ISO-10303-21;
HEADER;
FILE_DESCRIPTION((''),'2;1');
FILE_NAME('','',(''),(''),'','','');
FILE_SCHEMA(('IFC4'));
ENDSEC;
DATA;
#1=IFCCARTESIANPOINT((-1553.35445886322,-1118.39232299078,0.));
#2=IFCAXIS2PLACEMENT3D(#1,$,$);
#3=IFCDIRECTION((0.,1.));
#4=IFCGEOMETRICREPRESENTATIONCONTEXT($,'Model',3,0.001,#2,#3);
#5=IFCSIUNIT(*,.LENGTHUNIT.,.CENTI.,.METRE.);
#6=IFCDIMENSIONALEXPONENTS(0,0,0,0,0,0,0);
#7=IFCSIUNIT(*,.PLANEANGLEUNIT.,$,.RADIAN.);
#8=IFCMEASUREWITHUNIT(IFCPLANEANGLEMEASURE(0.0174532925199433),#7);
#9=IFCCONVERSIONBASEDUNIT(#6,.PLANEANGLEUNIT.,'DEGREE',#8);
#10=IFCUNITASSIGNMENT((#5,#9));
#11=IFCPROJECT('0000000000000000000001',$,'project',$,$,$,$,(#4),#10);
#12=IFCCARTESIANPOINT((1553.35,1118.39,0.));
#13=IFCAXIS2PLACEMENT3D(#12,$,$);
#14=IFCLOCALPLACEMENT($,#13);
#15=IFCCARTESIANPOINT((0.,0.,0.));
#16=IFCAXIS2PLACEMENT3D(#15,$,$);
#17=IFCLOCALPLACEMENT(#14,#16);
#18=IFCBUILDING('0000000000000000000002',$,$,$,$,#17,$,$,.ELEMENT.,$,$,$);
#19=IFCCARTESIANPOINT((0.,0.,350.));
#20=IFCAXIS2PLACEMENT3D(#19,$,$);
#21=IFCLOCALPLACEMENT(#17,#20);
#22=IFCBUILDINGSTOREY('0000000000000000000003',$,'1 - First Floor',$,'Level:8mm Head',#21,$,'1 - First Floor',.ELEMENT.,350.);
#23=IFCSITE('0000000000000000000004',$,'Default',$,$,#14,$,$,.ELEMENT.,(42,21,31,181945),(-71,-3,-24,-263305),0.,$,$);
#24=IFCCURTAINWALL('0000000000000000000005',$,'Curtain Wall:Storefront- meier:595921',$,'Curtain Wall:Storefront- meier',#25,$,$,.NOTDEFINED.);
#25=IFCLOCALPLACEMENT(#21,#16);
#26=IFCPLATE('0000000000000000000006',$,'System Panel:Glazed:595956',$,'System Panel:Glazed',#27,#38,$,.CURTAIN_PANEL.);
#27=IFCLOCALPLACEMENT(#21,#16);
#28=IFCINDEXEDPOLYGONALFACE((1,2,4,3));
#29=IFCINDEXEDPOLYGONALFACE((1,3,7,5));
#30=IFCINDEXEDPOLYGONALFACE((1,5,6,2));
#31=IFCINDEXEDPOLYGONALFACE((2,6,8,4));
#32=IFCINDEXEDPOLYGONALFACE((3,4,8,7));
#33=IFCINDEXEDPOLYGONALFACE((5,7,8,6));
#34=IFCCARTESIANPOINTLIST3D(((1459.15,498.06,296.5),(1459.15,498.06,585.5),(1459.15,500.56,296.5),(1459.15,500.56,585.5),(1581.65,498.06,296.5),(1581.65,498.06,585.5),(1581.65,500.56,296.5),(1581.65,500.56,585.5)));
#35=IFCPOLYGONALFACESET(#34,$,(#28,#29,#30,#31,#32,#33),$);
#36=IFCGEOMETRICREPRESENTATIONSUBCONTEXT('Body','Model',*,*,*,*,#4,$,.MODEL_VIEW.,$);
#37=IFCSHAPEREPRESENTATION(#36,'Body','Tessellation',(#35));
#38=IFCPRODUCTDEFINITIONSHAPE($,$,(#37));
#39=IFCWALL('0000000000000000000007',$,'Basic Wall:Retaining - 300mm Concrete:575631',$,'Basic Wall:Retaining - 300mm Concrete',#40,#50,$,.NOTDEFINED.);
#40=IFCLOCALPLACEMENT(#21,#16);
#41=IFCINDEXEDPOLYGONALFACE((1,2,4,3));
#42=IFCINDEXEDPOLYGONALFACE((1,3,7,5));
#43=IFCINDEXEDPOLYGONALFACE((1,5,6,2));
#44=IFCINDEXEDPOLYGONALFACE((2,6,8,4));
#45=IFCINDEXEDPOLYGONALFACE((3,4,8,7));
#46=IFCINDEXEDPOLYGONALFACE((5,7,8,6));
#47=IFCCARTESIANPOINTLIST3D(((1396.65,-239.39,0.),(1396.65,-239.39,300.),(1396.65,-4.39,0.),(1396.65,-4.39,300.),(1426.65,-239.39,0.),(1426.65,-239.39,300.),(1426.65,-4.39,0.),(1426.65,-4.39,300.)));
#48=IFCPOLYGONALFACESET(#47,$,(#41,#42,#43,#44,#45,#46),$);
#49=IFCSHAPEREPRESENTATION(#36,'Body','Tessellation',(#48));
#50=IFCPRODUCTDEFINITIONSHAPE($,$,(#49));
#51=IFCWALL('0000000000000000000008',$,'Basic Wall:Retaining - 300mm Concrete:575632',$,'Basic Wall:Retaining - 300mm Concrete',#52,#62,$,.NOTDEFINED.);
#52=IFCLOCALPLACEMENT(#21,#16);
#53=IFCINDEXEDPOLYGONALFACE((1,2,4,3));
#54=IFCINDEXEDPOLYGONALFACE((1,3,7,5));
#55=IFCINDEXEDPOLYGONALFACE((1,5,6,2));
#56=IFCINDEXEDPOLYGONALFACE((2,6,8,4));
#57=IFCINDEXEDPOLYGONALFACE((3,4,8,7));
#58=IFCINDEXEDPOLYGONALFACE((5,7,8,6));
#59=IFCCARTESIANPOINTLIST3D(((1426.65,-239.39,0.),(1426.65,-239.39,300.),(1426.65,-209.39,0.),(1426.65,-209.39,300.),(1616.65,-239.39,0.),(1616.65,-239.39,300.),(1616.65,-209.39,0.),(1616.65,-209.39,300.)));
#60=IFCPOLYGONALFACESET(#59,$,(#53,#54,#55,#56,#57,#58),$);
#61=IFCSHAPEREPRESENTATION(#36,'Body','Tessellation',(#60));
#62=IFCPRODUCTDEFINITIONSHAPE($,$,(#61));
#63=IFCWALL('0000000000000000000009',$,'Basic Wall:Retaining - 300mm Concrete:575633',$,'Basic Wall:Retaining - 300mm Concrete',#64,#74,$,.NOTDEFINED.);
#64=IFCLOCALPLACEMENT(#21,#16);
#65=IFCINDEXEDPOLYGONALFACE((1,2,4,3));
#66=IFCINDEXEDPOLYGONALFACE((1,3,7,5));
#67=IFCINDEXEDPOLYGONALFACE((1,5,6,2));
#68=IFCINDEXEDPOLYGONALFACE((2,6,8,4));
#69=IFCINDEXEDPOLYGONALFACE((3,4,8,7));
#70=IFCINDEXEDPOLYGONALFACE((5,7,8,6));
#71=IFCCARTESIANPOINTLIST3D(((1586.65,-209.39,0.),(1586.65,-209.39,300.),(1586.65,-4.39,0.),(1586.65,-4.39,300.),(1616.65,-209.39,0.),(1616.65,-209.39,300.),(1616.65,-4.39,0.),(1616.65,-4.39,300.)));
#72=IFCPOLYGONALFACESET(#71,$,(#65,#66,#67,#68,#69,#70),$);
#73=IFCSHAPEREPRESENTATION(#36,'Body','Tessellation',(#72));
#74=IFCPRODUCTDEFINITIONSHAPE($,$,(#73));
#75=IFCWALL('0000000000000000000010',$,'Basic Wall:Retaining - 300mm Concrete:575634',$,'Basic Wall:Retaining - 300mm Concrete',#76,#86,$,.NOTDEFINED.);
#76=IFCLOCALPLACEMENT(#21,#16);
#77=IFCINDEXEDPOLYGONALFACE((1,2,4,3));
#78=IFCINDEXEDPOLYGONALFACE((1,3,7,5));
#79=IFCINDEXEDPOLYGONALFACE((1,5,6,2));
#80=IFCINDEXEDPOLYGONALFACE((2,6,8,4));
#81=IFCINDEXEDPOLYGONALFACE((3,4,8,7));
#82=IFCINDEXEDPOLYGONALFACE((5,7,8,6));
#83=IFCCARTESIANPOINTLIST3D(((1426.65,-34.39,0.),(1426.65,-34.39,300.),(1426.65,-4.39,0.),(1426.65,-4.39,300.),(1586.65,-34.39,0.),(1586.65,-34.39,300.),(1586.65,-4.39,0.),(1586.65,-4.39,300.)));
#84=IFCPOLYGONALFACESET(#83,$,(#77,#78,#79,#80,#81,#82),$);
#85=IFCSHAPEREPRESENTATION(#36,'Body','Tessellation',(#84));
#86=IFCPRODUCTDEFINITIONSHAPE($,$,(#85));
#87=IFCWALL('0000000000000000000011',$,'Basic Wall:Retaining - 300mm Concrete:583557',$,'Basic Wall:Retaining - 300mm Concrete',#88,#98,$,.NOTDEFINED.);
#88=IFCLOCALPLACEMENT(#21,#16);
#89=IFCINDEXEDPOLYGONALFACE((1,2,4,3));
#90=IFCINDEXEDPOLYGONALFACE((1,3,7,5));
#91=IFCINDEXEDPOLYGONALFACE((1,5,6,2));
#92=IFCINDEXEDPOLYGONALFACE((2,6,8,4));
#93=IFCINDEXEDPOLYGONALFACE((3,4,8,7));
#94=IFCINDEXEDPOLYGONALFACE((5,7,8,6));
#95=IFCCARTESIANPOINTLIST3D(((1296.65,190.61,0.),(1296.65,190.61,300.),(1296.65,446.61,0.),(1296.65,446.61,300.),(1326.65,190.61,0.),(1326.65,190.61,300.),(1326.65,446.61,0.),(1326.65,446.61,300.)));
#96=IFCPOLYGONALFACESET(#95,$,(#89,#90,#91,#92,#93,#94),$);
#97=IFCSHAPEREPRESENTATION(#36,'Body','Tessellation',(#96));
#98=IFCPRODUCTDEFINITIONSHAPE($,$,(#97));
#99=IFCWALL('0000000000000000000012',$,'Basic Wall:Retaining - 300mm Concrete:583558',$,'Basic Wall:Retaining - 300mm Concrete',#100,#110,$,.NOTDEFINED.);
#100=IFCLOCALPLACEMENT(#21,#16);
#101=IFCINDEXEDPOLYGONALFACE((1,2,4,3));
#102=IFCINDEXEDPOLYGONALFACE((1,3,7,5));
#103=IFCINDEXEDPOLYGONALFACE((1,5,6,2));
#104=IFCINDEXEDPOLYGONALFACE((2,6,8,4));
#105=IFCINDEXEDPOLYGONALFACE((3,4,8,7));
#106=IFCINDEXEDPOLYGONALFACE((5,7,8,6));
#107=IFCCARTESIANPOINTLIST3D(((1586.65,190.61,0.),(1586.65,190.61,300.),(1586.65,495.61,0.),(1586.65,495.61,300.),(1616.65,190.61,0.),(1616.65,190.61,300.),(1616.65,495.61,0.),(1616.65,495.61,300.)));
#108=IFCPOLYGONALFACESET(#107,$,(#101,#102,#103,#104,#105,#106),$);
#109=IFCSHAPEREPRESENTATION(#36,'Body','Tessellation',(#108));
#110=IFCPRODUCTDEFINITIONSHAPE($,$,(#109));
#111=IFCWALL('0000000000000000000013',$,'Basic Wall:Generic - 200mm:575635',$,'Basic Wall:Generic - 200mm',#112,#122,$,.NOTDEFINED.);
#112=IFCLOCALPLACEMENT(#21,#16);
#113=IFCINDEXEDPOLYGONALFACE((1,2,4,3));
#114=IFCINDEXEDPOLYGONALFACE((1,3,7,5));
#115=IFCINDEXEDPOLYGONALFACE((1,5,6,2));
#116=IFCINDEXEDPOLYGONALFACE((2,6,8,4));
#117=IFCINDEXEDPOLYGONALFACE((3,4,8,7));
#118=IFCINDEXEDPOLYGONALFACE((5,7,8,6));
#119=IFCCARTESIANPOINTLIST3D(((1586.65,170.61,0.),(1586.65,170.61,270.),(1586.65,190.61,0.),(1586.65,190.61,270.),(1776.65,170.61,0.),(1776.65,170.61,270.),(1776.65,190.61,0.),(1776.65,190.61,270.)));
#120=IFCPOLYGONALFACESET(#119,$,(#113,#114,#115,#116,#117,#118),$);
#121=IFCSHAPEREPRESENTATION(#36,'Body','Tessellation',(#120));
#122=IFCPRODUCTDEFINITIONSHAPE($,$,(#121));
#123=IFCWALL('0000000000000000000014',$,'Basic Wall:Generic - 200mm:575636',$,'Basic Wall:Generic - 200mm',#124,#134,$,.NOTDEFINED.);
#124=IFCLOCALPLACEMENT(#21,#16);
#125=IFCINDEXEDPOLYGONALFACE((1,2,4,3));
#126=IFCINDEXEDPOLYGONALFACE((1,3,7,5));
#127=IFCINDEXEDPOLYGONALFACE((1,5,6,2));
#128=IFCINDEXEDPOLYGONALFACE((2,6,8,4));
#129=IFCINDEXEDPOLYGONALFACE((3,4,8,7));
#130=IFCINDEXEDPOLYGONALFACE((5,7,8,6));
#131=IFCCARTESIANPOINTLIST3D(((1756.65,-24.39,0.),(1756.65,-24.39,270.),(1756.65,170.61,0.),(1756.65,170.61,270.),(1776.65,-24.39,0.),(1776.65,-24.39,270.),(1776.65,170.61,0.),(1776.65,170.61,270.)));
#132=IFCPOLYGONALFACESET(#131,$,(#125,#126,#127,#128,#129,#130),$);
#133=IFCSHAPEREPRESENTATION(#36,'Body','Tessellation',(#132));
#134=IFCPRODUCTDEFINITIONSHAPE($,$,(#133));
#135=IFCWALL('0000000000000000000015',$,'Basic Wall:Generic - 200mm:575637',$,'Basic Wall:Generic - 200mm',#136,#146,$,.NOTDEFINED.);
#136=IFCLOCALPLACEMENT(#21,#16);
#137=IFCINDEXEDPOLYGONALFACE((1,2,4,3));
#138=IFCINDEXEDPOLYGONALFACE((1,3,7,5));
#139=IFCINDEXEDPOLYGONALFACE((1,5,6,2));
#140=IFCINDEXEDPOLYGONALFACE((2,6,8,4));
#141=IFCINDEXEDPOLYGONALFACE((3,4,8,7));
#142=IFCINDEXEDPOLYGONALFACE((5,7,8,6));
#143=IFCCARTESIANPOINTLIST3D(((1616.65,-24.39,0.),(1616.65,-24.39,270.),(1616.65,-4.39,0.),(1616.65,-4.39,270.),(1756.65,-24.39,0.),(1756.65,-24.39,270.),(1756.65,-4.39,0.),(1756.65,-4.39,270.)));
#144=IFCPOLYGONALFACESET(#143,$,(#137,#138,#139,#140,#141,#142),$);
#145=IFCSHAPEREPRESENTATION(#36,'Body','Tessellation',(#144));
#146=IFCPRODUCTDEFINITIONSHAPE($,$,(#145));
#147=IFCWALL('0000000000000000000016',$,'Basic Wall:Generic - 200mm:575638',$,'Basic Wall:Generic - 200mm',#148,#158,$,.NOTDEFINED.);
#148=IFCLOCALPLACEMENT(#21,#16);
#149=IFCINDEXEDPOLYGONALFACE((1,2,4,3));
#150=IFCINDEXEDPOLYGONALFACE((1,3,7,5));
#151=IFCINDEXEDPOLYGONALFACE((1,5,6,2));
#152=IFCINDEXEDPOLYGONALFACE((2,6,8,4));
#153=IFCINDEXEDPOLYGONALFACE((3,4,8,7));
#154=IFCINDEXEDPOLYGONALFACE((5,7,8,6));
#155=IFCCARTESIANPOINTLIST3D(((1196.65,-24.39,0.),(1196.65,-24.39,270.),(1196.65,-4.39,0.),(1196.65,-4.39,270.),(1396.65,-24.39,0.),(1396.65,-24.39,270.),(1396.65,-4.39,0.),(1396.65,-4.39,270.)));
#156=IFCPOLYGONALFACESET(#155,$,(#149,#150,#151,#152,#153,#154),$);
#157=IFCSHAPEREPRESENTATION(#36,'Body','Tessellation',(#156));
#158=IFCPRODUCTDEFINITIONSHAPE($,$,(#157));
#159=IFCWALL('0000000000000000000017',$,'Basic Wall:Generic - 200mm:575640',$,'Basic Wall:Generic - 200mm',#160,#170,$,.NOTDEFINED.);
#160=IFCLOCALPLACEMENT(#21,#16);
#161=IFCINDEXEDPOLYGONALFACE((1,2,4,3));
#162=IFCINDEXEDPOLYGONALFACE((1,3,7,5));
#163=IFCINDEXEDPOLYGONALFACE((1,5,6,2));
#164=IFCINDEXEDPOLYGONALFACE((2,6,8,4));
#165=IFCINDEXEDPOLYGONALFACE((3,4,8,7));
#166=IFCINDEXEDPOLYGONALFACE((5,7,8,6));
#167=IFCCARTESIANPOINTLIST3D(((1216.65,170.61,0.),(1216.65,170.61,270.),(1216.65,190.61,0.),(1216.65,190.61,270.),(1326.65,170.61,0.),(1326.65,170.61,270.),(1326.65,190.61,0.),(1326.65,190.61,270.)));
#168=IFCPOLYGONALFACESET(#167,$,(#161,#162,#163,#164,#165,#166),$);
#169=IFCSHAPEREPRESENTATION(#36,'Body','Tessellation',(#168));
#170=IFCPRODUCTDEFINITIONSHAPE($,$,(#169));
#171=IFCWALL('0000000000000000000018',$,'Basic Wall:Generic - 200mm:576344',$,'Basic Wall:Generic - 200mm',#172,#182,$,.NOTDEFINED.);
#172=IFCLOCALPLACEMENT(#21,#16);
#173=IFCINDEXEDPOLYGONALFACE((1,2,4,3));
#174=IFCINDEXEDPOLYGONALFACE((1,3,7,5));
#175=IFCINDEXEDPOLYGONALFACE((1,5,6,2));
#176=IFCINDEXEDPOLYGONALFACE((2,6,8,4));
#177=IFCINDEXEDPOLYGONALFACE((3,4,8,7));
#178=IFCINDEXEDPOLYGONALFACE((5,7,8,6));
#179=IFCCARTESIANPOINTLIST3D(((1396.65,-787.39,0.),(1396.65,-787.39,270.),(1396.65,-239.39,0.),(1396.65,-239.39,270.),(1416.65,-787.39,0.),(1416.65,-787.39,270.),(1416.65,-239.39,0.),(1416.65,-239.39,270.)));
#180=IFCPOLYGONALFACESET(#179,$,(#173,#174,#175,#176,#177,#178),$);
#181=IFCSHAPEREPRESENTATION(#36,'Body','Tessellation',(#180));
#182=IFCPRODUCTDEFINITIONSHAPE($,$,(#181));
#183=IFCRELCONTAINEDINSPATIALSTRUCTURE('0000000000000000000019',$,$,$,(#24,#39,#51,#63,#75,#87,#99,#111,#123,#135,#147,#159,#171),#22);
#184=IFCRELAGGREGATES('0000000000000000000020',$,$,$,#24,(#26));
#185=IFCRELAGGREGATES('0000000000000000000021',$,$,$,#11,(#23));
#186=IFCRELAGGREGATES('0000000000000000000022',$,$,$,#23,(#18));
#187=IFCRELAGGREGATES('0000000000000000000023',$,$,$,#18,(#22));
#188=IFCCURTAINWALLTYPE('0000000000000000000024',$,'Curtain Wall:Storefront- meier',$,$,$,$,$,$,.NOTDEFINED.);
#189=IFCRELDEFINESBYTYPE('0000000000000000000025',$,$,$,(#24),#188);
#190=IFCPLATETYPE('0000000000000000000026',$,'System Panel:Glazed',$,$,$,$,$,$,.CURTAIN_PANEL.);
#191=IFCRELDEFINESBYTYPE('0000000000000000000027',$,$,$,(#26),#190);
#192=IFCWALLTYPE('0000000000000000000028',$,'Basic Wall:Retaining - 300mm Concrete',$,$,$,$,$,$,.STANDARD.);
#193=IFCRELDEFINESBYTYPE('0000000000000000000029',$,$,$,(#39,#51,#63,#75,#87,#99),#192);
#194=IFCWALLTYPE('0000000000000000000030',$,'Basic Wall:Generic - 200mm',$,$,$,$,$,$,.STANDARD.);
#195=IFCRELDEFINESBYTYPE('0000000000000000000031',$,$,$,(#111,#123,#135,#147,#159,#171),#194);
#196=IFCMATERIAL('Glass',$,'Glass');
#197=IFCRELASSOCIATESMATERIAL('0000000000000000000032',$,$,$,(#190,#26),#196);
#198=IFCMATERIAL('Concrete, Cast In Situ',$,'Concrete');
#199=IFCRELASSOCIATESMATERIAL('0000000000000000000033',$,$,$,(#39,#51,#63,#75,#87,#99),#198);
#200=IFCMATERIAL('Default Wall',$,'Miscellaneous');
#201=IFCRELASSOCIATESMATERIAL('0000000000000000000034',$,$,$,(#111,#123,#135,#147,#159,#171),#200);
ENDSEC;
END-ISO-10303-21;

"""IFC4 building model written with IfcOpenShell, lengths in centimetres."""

from ifc_helpers import new_model, entity, si_unit, converted_unit, direction, frame, origin, place, context, subcontext, project, spatial, indexed_curve, outline, extrude, source, transform, mapped, material, type_object, type_shapes, element, aggregate, save


model = new_model("IFC4")

# Units and contexts
model_context = context("Model", 3, precision=0.001, world=frame((-1553.35445886322, -1118.39232299078, 0.0)), true_north=direction((0.0, 1.0)))
body_context = subcontext(model_context, "Body", "Model", "MODEL_VIEW")
ifc_project = project(units=[si_unit("LENGTHUNIT", "METRE", prefix="CENTI"), converted_unit("PLANEANGLEUNIT", "DEGREE", entity("IfcPlaneAngleMeasure", 0.0174532925199433), si_unit("PLANEANGLEUNIT", "RADIAN"), dimensions=[0, 0, 0, 0, 0, 0, 0])], contexts=[model_context])

# Site, building, storey
site_placement = place(None, frame((1553.35, 1118.39, 0.0)))
site = spatial("IfcSite", under=ifc_project, at=site_placement, Name="Default", CompositionType="ELEMENT", RefLatitude=(42, 21, 31, 181945), RefLongitude=(-71, -3, -24, -263305), RefElevation=0.0)
building_placement = place(site_placement, origin())
building = spatial("IfcBuilding", under=site, at=building_placement, CompositionType="ELEMENT")
storey_placement = place(building_placement, frame((0.0, 0.0, 350.0)))
storey = spatial("IfcBuildingStorey", under=building, at=storey_placement, Name="1 - First Floor", ObjectType="Level:8mm Head", LongName="1 - First Floor", CompositionType="ELEMENT", Elevation=350.0)

# Curtain wall, plate
curtain_wall_type = type_object("IfcCurtainWallType", Name="Curtain Wall:Storefront- meier", PredefinedType="NOTDEFINED")
curtain_wall_placement = place(storey_placement, frame((0.0, 0.0, -350.0)))
curtain_wall = element("IfcCurtainWall", 1, at=curtain_wall_placement, inside=storey, type_object=curtain_wall_type, Name="Curtain Wall:Storefront- meier:595921", ObjectType="Curtain Wall:Storefront- meier", PredefinedType="NOTDEFINED")
ifc_material_1 = material(Name="Glass", Category="Glass")
plate_type_1 = type_object("IfcPlateType", Name="System Panel:Glazed", PredefinedType="CURTAIN_PANEL", material=ifc_material_1)
shared_shape_1 = source(origin(), body_context, "Body", "SweptSolid", [
    extrude(outline(indexed_curve([(-1.25, -61.25), (1.25, -61.25), (1.25, 61.25), (-1.25, 61.25), (-1.25, -61.25)], self_intersect=False)), frame((0.0, 3.7, 0.0), z_axis=(0.0, 0.0, 1.0), x_axis=(0.0, 1.0, 0.0)), (0.0, 0.0, 1.0), 289.0),
])
type_shapes(plate_type_1, [shared_shape_1])
plate_1_placement = place(curtain_wall_placement, frame((1520.4, 495.61, 646.5)))
plate_1 = element("IfcPlate", 2, at=plate_1_placement, type_object=plate_type_1, material=ifc_material_1, Name="System Panel:Glazed:595956", ObjectType="System Panel:Glazed", PredefinedType="CURTAIN_PANEL", context=body_context, shape_type="MappedRepresentation", body=[
    mapped(shared_shape_1, transform((0.0, 0.0, 0.0), scale=1.0)),
])
aggregate(curtain_wall, [plate_1])

# Walls
ifc_material_2 = material(Name="Concrete, Cast In Situ", Category="Concrete")
wall_type_1 = type_object("IfcWallType", Name="Basic Wall:Retaining - 300mm Concrete", PredefinedType="STANDARD")
wall_1_placement = place(storey_placement, frame((1411.65, -4.39, 0.0), z_axis=(0.0, 0.0, 1.0), x_axis=(0.0, -1.0, 0.0)))
element("IfcWall", 3, at=wall_1_placement, inside=storey, type_object=wall_type_1, material=ifc_material_2, Name="Basic Wall:Retaining - 300mm Concrete:575631", ObjectType="Basic Wall:Retaining - 300mm Concrete", PredefinedType="NOTDEFINED", context=body_context, shape_type="SweptSolid", body=[
    extrude(outline(indexed_curve([(235.0, 15.0), (0.0, 15.0), (0.0, -15.0), (235.0, -15.0), (235.0, 15.0)], self_intersect=False)), origin(), (0.0, 0.0, 1.0), 300.0),
])
wall_2_placement = place(storey_placement, frame((1426.65, -224.39, 0.0)))
element("IfcWall", 4, at=wall_2_placement, inside=storey, type_object=wall_type_1, material=ifc_material_2, Name="Basic Wall:Retaining - 300mm Concrete:575632", ObjectType="Basic Wall:Retaining - 300mm Concrete", PredefinedType="NOTDEFINED", context=body_context, shape_type="SweptSolid", body=[
    extrude(outline(indexed_curve([(190.0, 15.0), (0.0, 15.0), (0.0, -15.0), (190.0, -15.0), (190.0, 15.0)], self_intersect=False)), origin(), (0.0, 0.0, 1.0), 300.0),
])
wall_3_placement = place(storey_placement, frame((1601.65, -209.39, 0.0), z_axis=(0.0, 0.0, 1.0), x_axis=(0.0, 1.0, 0.0)))
element("IfcWall", 5, at=wall_3_placement, inside=storey, type_object=wall_type_1, material=ifc_material_2, Name="Basic Wall:Retaining - 300mm Concrete:575633", ObjectType="Basic Wall:Retaining - 300mm Concrete", PredefinedType="NOTDEFINED", context=body_context, shape_type="SweptSolid", body=[
    extrude(outline(indexed_curve([(205.0, 15.0), (0.0, 15.0), (0.0, -15.0), (205.0, -15.0), (205.0, 15.0)], self_intersect=False)), origin(), (0.0, 0.0, 1.0), 300.0),
])
wall_4_placement = place(storey_placement, frame((1586.65, -19.39, 0.0), z_axis=(0.0, 0.0, 1.0), x_axis=(-1.0, 0.0, 0.0)))
element("IfcWall", 6, at=wall_4_placement, inside=storey, type_object=wall_type_1, material=ifc_material_2, Name="Basic Wall:Retaining - 300mm Concrete:575634", ObjectType="Basic Wall:Retaining - 300mm Concrete", PredefinedType="NOTDEFINED", context=body_context, shape_type="SweptSolid", body=[
    extrude(outline(indexed_curve([(160.0, 15.0), (0.0, 15.0), (0.0, -15.0), (160.0, -15.0), (160.0, 15.0)], self_intersect=False)), origin(), (0.0, 0.0, 1.0), 300.0),
])
wall_5_placement = place(storey_placement, frame((1311.65, 446.61, 0.0), z_axis=(0.0, 0.0, 1.0), x_axis=(0.0, -1.0, 0.0)))
element("IfcWall", 7, at=wall_5_placement, inside=storey, type_object=wall_type_1, material=ifc_material_2, Name="Basic Wall:Retaining - 300mm Concrete:583557", ObjectType="Basic Wall:Retaining - 300mm Concrete", PredefinedType="NOTDEFINED", context=body_context, shape_type="SweptSolid", body=[
    extrude(outline(indexed_curve([(256.0, 15.0), (0.0, 15.0), (0.0, -15.0), (256.0, -15.0), (256.0, 15.0)], self_intersect=False)), origin(), (0.0, 0.0, 1.0), 300.0),
])
wall_6_placement = place(storey_placement, frame((1601.65, 495.61, 0.0), z_axis=(0.0, 0.0, 1.0), x_axis=(0.0, -1.0, 0.0)))
element("IfcWall", 8, at=wall_6_placement, inside=storey, type_object=wall_type_1, material=ifc_material_2, Name="Basic Wall:Retaining - 300mm Concrete:583558", ObjectType="Basic Wall:Retaining - 300mm Concrete", PredefinedType="NOTDEFINED", context=body_context, shape_type="SweptSolid", body=[
    extrude(outline(indexed_curve([(305.0, 15.0), (0.0, 15.0), (0.0, -15.0), (305.0, -15.0), (305.0, 15.0)], self_intersect=False)), origin(), (0.0, 0.0, 1.0), 300.0),
])
ifc_material_3 = material(Name="Default Wall", Category="Miscellaneous")
wall_type_2 = type_object("IfcWallType", Name="Basic Wall:Generic - 200mm", PredefinedType="STANDARD")
wall_7_placement = place(storey_placement, frame((1586.65, 180.61, 0.0)))
element("IfcWall", 9, at=wall_7_placement, inside=storey, type_object=wall_type_2, material=ifc_material_3, Name="Basic Wall:Generic - 200mm:575635", ObjectType="Basic Wall:Generic - 200mm", PredefinedType="NOTDEFINED", context=body_context, shape_type="SweptSolid", body=[
    extrude(outline(indexed_curve([(190.0, 10.0), (0.0, 10.0), (0.0, -10.0), (190.0, -10.0), (190.0, 10.0)], self_intersect=False)), origin(), (0.0, 0.0, 1.0), 270.0),
])
wall_8_placement = place(storey_placement, frame((1766.65, 170.61, 0.0), z_axis=(0.0, 0.0, 1.0), x_axis=(0.0, -1.0, 0.0)))
element("IfcWall", 10, at=wall_8_placement, inside=storey, type_object=wall_type_2, material=ifc_material_3, Name="Basic Wall:Generic - 200mm:575636", ObjectType="Basic Wall:Generic - 200mm", PredefinedType="NOTDEFINED", context=body_context, shape_type="SweptSolid", body=[
    extrude(outline(indexed_curve([(195.0, 10.0), (0.0, 10.0), (0.0, -10.0), (195.0, -10.0), (195.0, 10.0)], self_intersect=False)), origin(), (0.0, 0.0, 1.0), 270.0),
])
wall_9_placement = place(storey_placement, frame((1616.65, -14.39, 0.0)))
element("IfcWall", 11, at=wall_9_placement, inside=storey, type_object=wall_type_2, material=ifc_material_3, Name="Basic Wall:Generic - 200mm:575637", ObjectType="Basic Wall:Generic - 200mm", PredefinedType="NOTDEFINED", context=body_context, shape_type="SweptSolid", body=[
    extrude(outline(indexed_curve([(140.0, 10.0), (0.0, 10.0), (0.0, -10.0), (140.0, -10.0), (140.0, 10.0)], self_intersect=False)), origin(), (0.0, 0.0, 1.0), 270.0),
])
wall_10_placement = place(storey_placement, frame((1396.65, -14.39, 0.0), z_axis=(0.0, 0.0, 1.0), x_axis=(-1.0, 0.0, 0.0)))
element("IfcWall", 12, at=wall_10_placement, inside=storey, type_object=wall_type_2, material=ifc_material_3, Name="Basic Wall:Generic - 200mm:575638", ObjectType="Basic Wall:Generic - 200mm", PredefinedType="NOTDEFINED", context=body_context, shape_type="SweptSolid", body=[
    extrude(outline(indexed_curve([(200.0, 10.0), (0.0, 10.0), (0.0, -10.0), (200.0, -10.0), (200.0, 10.0)], self_intersect=False)), origin(), (0.0, 0.0, 1.0), 270.0),
])
wall_11_placement = place(storey_placement, frame((1216.65, 180.61, 0.0)))
element("IfcWall", 13, at=wall_11_placement, inside=storey, type_object=wall_type_2, material=ifc_material_3, Name="Basic Wall:Generic - 200mm:575640", ObjectType="Basic Wall:Generic - 200mm", PredefinedType="NOTDEFINED", context=body_context, shape_type="SweptSolid", body=[
    extrude(outline(indexed_curve([(110.0, 10.0), (0.0, 10.0), (0.0, -10.0), (110.0, -10.0), (110.0, 10.0)], self_intersect=False)), origin(), (0.0, 0.0, 1.0), 270.0),
])
wall_12_placement = place(storey_placement, frame((1406.65, -239.39, 0.0), z_axis=(0.0, 0.0, 1.0), x_axis=(0.0, -1.0, 0.0)))
element("IfcWall", 14, at=wall_12_placement, inside=storey, type_object=wall_type_2, material=ifc_material_3, Name="Basic Wall:Generic - 200mm:576344", ObjectType="Basic Wall:Generic - 200mm", PredefinedType="NOTDEFINED", context=body_context, shape_type="SweptSolid", body=[
    extrude(outline(indexed_curve([(548.0, 10.0), (0.0, 10.0), (0.0, -10.0), (548.0, -10.0), (548.0, 10.0)], self_intersect=False)), origin(), (0.0, 0.0, 1.0), 270.0),
])

save(model, "model.ifc")
